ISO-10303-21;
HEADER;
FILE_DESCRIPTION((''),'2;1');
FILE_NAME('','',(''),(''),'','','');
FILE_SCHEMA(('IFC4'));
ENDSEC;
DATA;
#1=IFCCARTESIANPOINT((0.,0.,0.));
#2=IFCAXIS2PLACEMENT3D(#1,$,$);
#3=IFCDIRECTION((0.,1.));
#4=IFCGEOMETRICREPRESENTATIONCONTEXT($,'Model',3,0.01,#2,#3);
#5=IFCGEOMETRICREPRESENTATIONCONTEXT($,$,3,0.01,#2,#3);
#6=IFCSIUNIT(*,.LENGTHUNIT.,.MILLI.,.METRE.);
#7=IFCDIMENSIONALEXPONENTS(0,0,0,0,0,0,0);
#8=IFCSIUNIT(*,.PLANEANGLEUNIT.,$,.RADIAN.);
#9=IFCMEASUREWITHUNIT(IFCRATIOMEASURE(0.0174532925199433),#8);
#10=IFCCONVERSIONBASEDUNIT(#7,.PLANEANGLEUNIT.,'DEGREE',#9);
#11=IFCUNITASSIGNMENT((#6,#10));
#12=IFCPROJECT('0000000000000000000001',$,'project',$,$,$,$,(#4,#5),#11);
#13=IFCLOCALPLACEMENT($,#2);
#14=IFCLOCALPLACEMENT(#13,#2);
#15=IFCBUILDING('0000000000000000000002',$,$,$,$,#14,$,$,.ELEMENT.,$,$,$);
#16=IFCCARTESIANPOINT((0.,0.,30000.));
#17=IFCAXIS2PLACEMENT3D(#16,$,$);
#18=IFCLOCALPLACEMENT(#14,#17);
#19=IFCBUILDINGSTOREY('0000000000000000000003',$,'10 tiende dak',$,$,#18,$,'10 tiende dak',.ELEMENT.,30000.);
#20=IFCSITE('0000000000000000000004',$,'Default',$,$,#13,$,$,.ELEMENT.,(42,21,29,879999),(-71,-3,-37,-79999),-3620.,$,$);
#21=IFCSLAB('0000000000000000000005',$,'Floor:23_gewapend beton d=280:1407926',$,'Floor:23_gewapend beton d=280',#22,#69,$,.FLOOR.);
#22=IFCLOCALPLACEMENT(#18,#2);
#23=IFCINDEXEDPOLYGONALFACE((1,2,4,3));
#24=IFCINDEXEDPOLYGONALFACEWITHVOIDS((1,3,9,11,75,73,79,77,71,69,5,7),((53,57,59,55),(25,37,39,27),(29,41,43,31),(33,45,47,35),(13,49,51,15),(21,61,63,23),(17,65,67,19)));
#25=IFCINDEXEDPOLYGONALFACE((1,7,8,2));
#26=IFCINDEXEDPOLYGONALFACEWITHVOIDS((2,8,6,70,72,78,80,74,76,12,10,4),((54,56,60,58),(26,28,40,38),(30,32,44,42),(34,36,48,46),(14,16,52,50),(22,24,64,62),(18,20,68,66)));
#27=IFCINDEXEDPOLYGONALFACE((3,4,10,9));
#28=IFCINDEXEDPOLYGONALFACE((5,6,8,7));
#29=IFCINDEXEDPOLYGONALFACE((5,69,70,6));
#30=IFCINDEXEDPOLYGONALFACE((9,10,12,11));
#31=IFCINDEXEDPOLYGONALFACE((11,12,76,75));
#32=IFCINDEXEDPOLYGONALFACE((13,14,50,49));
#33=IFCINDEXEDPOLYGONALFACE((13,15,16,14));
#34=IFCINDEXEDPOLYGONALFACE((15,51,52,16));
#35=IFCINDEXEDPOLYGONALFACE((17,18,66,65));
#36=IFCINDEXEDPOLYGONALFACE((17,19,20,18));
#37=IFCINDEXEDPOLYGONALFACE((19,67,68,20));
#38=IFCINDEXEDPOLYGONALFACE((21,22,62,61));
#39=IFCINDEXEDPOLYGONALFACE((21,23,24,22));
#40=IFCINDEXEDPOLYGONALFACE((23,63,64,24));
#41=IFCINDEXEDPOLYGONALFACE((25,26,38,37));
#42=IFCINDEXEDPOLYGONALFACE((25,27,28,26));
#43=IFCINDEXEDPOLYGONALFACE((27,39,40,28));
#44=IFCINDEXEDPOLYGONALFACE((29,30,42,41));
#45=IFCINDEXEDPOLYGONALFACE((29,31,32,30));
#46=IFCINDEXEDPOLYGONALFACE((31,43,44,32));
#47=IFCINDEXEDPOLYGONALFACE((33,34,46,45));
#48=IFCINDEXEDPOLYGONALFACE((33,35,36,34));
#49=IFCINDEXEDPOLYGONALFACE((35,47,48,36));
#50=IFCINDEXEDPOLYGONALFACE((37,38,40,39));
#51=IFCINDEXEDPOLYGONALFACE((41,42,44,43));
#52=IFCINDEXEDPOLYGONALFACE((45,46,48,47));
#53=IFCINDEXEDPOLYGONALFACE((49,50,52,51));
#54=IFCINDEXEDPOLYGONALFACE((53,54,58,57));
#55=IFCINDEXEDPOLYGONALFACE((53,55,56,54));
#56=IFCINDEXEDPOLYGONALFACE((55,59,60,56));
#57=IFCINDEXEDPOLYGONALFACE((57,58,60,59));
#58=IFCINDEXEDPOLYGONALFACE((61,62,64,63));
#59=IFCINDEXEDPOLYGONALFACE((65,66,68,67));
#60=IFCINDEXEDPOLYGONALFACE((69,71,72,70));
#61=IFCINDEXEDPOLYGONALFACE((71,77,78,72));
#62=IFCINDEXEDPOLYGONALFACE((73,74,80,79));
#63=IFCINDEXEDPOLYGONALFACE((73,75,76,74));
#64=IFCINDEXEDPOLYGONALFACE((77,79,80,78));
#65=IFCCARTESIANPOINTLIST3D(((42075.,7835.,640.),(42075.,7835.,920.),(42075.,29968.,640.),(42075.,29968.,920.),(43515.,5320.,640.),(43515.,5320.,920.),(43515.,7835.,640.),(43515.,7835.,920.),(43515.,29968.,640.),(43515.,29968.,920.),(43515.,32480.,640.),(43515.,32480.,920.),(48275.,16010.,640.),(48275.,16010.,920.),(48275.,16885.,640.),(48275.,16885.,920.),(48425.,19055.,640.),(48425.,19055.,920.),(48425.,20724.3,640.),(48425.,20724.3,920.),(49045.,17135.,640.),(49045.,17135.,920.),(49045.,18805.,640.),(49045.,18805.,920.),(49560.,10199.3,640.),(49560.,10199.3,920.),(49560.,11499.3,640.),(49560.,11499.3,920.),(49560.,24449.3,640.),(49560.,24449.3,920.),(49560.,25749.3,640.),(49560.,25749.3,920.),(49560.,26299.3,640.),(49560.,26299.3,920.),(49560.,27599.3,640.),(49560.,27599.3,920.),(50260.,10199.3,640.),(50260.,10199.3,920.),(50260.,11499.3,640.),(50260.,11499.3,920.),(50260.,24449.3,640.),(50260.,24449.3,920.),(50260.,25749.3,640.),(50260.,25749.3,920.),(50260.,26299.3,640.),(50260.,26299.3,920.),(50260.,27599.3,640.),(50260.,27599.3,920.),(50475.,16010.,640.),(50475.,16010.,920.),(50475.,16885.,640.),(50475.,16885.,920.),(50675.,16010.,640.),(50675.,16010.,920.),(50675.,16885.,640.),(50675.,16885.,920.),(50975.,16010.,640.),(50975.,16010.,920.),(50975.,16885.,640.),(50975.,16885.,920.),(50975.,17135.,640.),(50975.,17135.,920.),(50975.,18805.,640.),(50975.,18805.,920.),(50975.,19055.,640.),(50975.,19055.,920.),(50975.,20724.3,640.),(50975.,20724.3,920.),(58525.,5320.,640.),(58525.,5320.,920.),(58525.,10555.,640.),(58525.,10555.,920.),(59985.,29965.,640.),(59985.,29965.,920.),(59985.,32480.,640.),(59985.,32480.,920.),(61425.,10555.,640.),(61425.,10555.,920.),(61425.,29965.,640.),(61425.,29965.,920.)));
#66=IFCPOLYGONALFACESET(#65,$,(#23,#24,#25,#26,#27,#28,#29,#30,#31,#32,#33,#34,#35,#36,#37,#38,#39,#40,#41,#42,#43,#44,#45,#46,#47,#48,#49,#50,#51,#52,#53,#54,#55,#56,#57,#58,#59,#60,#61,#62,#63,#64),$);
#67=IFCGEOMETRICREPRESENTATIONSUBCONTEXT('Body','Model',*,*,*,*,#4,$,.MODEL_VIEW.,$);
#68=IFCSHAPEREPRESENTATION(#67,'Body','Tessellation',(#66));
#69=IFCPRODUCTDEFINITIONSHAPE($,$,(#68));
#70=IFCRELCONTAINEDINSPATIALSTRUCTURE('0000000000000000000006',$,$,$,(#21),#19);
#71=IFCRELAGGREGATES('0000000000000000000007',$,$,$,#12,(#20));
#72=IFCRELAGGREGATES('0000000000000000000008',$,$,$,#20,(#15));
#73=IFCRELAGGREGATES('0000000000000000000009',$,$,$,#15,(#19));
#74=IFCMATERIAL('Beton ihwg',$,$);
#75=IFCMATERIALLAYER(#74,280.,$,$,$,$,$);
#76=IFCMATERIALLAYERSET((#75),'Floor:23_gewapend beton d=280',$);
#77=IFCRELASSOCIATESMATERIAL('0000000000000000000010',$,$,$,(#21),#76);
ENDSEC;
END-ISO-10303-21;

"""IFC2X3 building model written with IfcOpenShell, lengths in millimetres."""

from ifc_helpers import new_model, entity, si_unit, converted_unit, direction, frame, frame_2d, origin, place, context, subcontext, project, spatial, polyline, rectangle, outline, extrude, material, layer, layer_set, layer_usage, element, save


model = new_model("IFC2X3")

# Units and contexts
model_context = context("Model", 3, precision=0.01, world=origin(), true_north=direction((0.0, 1.0)))
context_of_model = context(None, 3, precision=0.01, world=origin(), true_north=direction((0.0, 1.0)))
body_context = subcontext(model_context, "Body", "Model", "MODEL_VIEW")
ifc_project = project(units=[si_unit("LENGTHUNIT", "METRE", prefix="MILLI"), converted_unit("PLANEANGLEUNIT", "DEGREE", entity("IfcRatioMeasure", 0.0174532925199433), si_unit("PLANEANGLEUNIT", "RADIAN"), dimensions=[0, 0, 0, 0, 0, 0, 0])], contexts=[model_context, context_of_model])

# Site, building, storey
site_placement = place(None, origin())
site = spatial("IfcSite", under=ifc_project, at=site_placement, Name="Default", CompositionType="ELEMENT", RefLatitude=(42, 21, 29, 879999), RefLongitude=(-71, -3, -37, -79999), RefElevation=-3620.0)
building_placement = place(site_placement, origin())
building = spatial("IfcBuilding", under=site, at=building_placement, CompositionType="ELEMENT")
storey_placement = place(building_placement, frame((0.0, 0.0, 30000.0)))
storey = spatial("IfcBuildingStorey", under=building, at=storey_placement, Name="10 tiende dak", LongName="10 tiende dak", CompositionType="ELEMENT", Elevation=30000.0)

# Slab, openings
ifc_material = material(Name="Beton ihwg")
ifc_layer = layer(ifc_material, 280.0)
ifc_layer_set = layer_set([ifc_layer], Name="Floor:23_gewapend beton d=280")
ifc_layer_usage = layer_usage(ifc_layer_set, "AXIS3", "POSITIVE", 0.0)
slab_placement = place(storey_placement, frame((42075.0, 5320.0, 640.0)))
slab = element("IfcSlab", 1, at=slab_placement, inside=storey, material=ifc_layer_usage, Name="Floor:23_gewapend beton d=280:1407926", ObjectType="Floor:23_gewapend beton d=280", PredefinedType="FLOOR", context=body_context, shape_type="SweptSolid", body=[
    extrude(outline(polyline([(-8235.0, 13580.0), (-8235.0, 11065.0), (-9675.0, 11065.0), (-9675.0, -8345.0), (-6775.0, -8345.0), (-6775.0, -13580.0), (8235.0, -13580.0), (8235.0, -11065.0), (9675.0, -11065.0), (9675.0, 11068.0), (8235.0, 11068.0), (8235.0, 13580.0), (-8235.0, 13580.0)])), frame((9675.0, 13580.0, 280.0), z_axis=(0.0, 0.0, -1.0), x_axis=(-1.0, 0.0, 0.0)), (0.0, 0.0, 1.0), 280.0),
])
opening_1_placement = place(storey_placement, frame((42075.0, 5320.0, 640.0)))
element("IfcOpeningElement", 2, at=opening_1_placement, cuts=slab, ObjectType="Opening", context=body_context, shape_type="SweptSolid", body=[
    extrude(rectangle(XDim=1669.3, YDim=2550.0, at=frame_2d((2050.0, 989.6), x_axis=(0.0, 1.0))), frame((9675.0, 13580.0, 280.0), z_axis=(0.0, 0.0, -1.0), x_axis=(-1.0, 0.0, 0.0)), (0.0, 0.0, 1.0), 280.0),
])
opening_2_placement = place(storey_placement, frame((42075.0, 5320.0, 640.0)))
element("IfcOpeningElement", 3, at=opening_2_placement, cuts=slab, ObjectType="Opening", context=body_context, shape_type="SweptSolid", body=[
    extrude(rectangle(XDim=1670.0, YDim=1930.0, at=frame_2d((1740.0, -930.0), x_axis=(0.0, 1.0))), frame((9675.0, 13580.0, 280.0), z_axis=(0.0, 0.0, -1.0), x_axis=(-1.0, 0.0, 0.0)), (0.0, 0.0, 1.0), 280.0),
])
opening_3_placement = place(storey_placement, frame((42075.0, 5320.0, 640.0)))
element("IfcOpeningElement", 4, at=opening_3_placement, cuts=slab, ObjectType="Opening", context=body_context, shape_type="SweptSolid", body=[
    extrude(rectangle(XDim=1300.0, YDim=700.0, at=frame_2d((1840.0, 8049.3), x_axis=(0.0, 1.0))), frame((9675.0, 13580.0, 280.0), z_axis=(0.0, 0.0, -1.0), x_axis=(-1.0, 0.0, 0.0)), (0.0, 0.0, 1.0), 280.0),
])
opening_4_placement = place(storey_placement, frame((42075.0, 5320.0, 640.0)))
element("IfcOpeningElement", 5, at=opening_4_placement, cuts=slab, ObjectType="Opening", context=body_context, shape_type="SweptSolid", body=[
    extrude(rectangle(XDim=1300.0, YDim=700.0, at=frame_2d((1840.0, 6199.3), x_axis=(0.0, 1.0))), frame((9675.0, 13580.0, 280.0), z_axis=(0.0, 0.0, -1.0), x_axis=(-1.0, 0.0, 0.0)), (0.0, 0.0, 1.0), 280.0),
])
opening_5_placement = place(storey_placement, frame((42075.0, 5320.0, 640.0)))
element("IfcOpeningElement", 6, at=opening_5_placement, cuts=slab, ObjectType="Opening", context=body_context, shape_type="SweptSolid", body=[
    extrude(rectangle(XDim=1300.0, YDim=700.0, at=frame_2d((1840.0, -8050.7), x_axis=(0.0, 1.0))), frame((9675.0, 13580.0, 280.0), z_axis=(0.0, 0.0, -1.0), x_axis=(-1.0, 0.0, 0.0)), (0.0, 0.0, 1.0), 280.0),
])
opening_6_placement = place(storey_placement, frame((42075.0, 5320.0, 640.0)))
element("IfcOpeningElement", 7, at=opening_6_placement, cuts=slab, ObjectType="Opening", context=body_context, shape_type="SweptSolid", body=[
    extrude(rectangle(XDim=875.0, YDim=2200.0, at=frame_2d((2375.0, -2452.5), x_axis=(0.0, 1.0))), frame((9675.0, 13580.0, 280.0), z_axis=(0.0, 0.0, -1.0), x_axis=(-1.0, 0.0, 0.0)), (0.0, 0.0, 1.0), 280.0),
])
opening_7_placement = place(storey_placement, frame((42075.0, 5320.0, 640.0)))
element("IfcOpeningElement", 8, at=opening_7_placement, cuts=slab, ObjectType="Opening", context=body_context, shape_type="SweptSolid", body=[
    extrude(rectangle(XDim=875.0, YDim=300.0, at=frame_2d((925.0, -2452.5), x_axis=(0.0, 1.0))), frame((9675.0, 13580.0, 280.0), z_axis=(0.0, 0.0, -1.0), x_axis=(-1.0, 0.0, 0.0)), (0.0, 0.0, 1.0), 280.0),
])

save(model, "model.ifc")
